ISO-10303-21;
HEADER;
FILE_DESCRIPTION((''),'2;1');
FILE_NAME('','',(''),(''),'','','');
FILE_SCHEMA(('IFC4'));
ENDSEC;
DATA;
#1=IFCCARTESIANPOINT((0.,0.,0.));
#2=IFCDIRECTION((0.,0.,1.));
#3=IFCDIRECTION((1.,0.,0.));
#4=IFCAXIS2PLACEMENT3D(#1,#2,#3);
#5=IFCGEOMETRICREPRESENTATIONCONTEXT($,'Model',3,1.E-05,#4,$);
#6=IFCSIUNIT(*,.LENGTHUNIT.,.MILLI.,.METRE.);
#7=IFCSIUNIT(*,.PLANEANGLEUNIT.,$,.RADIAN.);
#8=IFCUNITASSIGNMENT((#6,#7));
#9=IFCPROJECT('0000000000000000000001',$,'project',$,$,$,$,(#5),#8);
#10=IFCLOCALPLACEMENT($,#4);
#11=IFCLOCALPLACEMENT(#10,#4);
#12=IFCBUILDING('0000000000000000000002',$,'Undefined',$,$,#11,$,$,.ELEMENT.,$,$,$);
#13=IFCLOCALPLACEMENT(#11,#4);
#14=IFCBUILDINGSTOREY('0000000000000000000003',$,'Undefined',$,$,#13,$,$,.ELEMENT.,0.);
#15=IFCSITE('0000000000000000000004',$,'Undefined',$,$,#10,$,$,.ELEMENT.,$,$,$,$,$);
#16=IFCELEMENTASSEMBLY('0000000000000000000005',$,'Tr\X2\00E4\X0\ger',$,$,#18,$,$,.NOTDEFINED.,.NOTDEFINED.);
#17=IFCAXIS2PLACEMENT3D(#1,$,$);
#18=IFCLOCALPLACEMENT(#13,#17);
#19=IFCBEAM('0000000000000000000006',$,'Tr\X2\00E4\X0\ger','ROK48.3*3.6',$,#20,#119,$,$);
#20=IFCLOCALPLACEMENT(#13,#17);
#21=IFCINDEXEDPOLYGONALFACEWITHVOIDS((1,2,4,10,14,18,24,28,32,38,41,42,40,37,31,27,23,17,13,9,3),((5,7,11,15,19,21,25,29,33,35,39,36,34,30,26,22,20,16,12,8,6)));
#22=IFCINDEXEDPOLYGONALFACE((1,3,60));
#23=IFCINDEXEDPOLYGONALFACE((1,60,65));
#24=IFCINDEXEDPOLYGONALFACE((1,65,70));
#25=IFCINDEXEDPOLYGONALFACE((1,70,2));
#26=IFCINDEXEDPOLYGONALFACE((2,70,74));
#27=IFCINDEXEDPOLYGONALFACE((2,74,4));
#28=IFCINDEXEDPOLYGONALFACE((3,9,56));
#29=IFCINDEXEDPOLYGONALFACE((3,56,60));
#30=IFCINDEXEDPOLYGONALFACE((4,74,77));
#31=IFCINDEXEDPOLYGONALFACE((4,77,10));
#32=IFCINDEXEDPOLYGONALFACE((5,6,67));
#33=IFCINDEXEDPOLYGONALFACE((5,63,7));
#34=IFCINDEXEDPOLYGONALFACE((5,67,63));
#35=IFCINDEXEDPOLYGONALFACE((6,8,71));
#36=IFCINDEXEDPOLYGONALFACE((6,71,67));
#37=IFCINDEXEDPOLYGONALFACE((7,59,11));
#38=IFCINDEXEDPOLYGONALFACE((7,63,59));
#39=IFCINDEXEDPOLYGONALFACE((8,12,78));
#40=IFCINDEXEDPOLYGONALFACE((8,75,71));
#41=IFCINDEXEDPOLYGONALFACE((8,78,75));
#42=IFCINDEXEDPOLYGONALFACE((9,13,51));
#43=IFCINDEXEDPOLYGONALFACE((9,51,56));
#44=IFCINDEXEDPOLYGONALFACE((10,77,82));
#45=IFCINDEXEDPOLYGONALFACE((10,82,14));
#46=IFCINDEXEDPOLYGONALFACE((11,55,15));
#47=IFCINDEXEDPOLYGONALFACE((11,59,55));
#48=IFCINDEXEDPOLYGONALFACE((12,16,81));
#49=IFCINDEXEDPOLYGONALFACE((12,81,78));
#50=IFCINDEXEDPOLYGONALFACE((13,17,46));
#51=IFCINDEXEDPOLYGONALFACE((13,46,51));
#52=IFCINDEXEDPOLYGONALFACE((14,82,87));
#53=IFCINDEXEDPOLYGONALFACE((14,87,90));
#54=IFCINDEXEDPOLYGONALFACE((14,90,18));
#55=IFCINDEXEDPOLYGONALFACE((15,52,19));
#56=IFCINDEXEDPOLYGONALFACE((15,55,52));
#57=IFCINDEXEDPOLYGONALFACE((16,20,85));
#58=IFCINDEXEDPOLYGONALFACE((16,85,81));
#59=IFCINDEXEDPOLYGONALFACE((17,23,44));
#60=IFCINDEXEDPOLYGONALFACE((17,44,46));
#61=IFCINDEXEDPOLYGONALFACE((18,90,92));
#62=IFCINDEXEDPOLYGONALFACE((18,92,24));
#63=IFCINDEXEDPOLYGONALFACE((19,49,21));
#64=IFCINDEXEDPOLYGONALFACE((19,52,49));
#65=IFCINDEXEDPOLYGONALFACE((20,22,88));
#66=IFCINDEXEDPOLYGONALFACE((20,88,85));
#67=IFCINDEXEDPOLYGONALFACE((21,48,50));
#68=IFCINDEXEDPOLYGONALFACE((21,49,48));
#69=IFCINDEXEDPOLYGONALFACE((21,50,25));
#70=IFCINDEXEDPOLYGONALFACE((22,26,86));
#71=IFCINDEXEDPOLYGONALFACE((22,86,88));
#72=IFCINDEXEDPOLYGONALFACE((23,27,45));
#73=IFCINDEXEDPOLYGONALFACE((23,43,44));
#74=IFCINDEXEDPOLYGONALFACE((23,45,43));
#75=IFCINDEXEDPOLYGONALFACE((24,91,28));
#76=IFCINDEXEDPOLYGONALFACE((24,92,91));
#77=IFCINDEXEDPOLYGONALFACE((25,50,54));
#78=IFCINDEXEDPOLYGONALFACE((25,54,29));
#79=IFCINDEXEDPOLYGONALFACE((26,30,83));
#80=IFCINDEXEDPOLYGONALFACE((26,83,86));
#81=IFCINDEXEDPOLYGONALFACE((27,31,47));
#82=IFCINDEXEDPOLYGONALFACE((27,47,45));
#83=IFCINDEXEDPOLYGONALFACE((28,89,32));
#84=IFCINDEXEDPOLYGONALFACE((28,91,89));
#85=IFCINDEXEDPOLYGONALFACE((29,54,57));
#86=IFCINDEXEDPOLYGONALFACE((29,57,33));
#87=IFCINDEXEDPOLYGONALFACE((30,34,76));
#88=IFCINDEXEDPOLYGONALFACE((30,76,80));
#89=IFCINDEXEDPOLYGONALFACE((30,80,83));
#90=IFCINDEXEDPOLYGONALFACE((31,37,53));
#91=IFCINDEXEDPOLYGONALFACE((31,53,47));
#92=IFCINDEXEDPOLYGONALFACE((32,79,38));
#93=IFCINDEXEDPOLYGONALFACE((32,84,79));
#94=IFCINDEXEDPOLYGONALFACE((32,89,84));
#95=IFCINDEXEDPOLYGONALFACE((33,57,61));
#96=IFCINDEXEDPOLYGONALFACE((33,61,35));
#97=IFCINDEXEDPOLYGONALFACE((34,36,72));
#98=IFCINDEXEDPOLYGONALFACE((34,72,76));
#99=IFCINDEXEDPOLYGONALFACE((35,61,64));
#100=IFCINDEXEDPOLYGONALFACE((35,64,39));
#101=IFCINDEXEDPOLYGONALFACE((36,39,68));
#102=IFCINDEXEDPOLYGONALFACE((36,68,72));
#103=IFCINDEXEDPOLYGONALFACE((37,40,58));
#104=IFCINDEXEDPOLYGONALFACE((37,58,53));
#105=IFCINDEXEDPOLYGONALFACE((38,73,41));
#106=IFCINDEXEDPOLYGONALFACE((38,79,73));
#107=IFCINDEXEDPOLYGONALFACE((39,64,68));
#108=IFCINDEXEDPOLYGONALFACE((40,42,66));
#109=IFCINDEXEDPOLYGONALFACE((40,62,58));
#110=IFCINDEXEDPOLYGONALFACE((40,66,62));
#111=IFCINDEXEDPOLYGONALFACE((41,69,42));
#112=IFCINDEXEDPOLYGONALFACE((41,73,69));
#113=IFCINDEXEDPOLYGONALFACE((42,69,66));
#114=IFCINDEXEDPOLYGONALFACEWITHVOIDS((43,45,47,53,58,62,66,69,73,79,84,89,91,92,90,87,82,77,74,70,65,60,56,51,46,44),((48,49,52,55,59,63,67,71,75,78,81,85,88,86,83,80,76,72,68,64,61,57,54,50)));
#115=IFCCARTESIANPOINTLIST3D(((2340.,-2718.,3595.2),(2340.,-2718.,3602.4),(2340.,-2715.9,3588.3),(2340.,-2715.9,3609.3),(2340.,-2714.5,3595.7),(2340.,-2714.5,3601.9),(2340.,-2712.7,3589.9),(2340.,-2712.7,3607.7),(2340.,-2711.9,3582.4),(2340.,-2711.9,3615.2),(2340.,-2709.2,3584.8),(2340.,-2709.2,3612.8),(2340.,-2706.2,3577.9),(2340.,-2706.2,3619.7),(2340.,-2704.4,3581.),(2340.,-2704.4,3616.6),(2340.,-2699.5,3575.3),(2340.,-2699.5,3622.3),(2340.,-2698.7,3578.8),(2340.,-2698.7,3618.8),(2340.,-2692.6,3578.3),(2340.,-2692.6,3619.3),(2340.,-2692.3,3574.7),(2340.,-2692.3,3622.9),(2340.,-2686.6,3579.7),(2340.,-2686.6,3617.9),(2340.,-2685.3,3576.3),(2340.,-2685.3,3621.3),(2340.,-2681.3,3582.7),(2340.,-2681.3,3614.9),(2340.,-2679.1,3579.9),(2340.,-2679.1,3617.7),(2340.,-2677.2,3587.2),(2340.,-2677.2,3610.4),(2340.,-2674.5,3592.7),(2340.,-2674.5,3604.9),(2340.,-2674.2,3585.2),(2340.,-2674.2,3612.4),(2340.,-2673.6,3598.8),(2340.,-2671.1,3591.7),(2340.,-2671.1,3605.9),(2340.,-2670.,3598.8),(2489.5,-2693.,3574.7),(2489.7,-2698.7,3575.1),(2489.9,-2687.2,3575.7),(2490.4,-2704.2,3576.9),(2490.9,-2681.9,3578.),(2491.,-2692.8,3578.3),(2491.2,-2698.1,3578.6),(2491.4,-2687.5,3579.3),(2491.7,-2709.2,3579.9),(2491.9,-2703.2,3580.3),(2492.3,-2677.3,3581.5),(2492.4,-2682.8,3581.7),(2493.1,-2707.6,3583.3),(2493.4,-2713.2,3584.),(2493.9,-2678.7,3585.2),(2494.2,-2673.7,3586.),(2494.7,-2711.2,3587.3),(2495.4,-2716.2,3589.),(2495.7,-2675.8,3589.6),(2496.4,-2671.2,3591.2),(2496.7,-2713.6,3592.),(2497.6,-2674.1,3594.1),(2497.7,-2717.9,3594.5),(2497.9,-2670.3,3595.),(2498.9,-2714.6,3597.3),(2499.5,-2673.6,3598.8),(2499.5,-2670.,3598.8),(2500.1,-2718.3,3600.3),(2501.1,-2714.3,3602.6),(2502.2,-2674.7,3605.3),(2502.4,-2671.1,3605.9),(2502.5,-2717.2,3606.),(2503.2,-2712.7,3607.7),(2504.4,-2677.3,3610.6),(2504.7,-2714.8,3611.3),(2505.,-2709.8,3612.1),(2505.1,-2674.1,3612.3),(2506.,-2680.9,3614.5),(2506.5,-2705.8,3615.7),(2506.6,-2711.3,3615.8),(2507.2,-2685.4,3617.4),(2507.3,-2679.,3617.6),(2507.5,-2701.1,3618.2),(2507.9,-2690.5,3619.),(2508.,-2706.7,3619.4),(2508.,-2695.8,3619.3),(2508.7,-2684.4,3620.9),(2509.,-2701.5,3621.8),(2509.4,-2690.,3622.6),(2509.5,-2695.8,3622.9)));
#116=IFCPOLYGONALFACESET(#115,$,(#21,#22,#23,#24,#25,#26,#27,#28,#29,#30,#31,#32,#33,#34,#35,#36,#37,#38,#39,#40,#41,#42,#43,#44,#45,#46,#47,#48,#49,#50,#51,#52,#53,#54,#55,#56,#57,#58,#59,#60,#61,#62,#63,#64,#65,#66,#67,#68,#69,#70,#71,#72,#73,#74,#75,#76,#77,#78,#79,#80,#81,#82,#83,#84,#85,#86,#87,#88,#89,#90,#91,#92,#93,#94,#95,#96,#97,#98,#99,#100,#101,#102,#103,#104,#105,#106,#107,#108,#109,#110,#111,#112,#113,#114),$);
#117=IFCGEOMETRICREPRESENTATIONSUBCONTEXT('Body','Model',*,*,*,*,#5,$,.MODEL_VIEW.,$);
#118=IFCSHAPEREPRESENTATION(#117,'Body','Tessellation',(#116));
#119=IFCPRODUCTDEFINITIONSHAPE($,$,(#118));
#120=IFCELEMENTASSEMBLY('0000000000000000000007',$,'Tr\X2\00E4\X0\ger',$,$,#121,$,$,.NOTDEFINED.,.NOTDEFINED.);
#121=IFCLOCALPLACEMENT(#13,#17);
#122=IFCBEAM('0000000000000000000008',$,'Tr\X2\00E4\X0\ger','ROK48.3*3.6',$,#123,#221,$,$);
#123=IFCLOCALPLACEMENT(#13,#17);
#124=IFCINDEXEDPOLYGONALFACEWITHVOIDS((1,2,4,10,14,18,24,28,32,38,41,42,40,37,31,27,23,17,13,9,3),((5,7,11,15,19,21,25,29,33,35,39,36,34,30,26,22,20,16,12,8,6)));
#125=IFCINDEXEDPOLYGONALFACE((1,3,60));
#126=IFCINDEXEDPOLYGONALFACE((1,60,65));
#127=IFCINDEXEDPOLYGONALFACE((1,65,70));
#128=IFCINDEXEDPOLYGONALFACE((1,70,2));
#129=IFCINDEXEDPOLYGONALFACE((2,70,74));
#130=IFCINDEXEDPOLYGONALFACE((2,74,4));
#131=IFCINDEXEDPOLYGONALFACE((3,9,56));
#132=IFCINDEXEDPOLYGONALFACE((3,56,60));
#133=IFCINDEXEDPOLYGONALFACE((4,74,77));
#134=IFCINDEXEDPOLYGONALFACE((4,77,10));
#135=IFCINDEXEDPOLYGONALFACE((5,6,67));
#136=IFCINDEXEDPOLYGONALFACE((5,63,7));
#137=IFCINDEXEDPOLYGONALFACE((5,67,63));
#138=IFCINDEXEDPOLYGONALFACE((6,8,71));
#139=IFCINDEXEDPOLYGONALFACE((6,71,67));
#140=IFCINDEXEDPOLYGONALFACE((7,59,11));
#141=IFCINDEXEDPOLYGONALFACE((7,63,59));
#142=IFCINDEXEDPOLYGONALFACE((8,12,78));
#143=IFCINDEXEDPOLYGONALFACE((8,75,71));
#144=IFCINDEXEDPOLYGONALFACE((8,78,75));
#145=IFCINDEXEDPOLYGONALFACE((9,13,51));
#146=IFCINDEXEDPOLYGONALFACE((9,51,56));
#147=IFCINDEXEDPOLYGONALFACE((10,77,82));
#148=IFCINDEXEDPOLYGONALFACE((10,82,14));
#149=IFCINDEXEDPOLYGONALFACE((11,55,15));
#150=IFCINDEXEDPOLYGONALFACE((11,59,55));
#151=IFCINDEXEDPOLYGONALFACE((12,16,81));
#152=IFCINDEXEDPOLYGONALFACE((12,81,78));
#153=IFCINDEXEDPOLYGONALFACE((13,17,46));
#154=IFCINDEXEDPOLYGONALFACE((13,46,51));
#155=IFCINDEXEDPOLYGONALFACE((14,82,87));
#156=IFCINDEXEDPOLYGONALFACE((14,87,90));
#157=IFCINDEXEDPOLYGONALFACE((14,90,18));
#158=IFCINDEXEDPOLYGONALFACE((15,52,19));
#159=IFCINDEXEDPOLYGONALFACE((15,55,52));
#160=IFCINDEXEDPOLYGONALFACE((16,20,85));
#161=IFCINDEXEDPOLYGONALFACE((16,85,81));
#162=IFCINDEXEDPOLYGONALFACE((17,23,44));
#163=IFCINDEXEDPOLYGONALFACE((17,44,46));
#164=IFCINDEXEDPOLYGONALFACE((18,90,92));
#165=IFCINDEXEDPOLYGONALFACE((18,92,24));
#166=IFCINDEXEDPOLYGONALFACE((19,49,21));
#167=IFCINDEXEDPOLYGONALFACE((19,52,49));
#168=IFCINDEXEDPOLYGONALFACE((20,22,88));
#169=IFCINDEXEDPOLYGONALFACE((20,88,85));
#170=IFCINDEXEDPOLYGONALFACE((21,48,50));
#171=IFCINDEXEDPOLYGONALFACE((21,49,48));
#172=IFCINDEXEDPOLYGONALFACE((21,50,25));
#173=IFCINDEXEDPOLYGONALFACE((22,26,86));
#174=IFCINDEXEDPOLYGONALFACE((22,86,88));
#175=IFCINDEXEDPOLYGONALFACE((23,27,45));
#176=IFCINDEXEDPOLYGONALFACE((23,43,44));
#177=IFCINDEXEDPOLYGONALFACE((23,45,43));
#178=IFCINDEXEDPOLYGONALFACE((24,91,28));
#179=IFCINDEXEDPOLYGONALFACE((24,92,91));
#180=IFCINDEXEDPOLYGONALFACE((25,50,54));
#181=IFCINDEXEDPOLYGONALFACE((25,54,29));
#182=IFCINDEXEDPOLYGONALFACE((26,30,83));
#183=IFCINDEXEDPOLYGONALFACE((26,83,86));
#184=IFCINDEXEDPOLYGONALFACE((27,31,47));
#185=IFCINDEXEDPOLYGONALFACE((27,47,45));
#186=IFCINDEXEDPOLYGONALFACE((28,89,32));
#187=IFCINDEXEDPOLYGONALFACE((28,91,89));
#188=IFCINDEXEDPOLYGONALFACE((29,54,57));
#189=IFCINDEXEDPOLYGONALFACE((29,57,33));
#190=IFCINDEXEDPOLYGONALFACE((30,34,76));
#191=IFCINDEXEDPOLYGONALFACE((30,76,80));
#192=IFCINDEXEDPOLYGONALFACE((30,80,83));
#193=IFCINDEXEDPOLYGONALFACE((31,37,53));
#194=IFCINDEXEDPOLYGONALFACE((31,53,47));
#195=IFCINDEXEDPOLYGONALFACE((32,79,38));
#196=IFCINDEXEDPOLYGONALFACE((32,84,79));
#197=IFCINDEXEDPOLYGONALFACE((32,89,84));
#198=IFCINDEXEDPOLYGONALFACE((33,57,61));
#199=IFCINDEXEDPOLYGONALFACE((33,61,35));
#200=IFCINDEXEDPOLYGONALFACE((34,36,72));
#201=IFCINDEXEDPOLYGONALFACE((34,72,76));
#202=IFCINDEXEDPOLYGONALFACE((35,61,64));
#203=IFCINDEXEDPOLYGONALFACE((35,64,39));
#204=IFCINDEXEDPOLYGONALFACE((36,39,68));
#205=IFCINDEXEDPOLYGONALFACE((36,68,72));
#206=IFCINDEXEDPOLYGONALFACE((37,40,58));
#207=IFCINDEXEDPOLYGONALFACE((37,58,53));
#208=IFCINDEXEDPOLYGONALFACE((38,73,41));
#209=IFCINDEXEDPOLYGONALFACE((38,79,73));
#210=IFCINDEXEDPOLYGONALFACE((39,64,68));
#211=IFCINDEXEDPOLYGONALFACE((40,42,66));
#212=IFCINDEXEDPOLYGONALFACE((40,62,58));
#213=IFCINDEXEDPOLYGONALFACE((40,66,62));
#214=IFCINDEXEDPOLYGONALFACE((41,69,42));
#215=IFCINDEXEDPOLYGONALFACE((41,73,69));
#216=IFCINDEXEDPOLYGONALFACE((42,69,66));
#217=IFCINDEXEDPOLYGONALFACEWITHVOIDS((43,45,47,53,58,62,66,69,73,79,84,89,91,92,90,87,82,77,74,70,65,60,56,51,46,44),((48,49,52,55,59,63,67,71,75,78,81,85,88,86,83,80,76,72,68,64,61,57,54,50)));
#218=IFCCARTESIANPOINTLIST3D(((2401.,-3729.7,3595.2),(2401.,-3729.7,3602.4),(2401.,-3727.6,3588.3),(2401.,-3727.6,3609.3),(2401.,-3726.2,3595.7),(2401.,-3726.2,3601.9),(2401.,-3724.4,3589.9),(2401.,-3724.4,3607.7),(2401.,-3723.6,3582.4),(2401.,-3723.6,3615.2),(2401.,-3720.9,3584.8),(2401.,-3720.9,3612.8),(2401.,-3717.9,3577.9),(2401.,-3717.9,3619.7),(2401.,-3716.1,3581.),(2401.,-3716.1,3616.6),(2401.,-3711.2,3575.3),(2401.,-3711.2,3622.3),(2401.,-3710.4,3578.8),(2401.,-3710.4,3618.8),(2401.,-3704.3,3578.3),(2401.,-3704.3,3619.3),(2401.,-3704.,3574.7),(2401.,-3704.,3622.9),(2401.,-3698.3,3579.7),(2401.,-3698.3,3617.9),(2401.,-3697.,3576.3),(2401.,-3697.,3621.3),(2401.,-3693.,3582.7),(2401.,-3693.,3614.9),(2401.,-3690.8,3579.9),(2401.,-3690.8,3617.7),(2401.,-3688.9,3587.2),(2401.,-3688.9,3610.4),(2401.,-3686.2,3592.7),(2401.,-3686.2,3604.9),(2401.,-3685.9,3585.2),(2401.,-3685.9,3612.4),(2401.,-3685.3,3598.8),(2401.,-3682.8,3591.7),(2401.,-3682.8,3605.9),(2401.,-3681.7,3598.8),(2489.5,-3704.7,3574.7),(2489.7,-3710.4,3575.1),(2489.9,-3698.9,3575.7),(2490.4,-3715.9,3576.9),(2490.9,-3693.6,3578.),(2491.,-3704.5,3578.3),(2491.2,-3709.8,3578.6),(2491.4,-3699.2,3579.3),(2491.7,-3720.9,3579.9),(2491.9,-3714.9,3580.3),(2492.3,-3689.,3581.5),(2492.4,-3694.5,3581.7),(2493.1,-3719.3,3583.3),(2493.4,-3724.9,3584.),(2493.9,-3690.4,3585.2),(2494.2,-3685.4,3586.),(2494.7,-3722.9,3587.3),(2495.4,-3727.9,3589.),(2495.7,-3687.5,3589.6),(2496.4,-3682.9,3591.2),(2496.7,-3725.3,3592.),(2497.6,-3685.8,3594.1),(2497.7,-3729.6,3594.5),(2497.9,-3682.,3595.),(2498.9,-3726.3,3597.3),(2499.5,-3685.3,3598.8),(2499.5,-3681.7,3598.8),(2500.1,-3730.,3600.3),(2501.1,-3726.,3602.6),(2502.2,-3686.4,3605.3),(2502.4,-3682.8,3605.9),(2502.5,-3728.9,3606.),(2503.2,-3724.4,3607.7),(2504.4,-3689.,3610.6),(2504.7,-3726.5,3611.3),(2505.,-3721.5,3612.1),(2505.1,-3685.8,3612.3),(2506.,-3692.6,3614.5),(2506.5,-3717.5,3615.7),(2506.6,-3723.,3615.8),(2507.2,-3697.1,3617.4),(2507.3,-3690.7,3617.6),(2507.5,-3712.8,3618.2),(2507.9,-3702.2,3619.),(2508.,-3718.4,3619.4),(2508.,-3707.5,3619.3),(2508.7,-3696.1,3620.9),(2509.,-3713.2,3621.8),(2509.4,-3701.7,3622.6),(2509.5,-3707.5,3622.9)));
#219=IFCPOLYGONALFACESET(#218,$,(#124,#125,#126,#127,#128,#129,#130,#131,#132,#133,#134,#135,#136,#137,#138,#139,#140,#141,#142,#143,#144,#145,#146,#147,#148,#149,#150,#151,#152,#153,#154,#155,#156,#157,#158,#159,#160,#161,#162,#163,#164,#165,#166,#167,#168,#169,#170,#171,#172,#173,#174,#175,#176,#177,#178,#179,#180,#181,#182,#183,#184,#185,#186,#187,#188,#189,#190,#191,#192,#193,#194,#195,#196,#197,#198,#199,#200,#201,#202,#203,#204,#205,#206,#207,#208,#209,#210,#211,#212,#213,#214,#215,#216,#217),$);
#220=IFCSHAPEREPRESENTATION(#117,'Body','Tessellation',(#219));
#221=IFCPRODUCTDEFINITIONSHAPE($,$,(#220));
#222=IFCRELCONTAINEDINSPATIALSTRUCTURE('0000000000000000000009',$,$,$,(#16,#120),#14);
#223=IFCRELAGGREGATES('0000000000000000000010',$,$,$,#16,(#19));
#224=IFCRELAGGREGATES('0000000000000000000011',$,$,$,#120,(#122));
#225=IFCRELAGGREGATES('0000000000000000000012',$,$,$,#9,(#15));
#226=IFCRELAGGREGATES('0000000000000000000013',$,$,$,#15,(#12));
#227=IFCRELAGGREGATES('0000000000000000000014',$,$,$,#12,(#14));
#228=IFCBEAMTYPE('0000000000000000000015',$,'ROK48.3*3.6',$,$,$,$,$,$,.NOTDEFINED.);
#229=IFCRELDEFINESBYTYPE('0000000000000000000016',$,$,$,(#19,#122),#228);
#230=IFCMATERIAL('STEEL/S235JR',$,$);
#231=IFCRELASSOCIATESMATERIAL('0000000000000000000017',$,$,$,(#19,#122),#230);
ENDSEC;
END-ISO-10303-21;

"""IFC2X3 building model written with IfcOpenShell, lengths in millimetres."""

from ifc_helpers import new_model, si_unit, frame, origin_with_axes, origin_2d_with_axis, place, context, subcontext, project, spatial, hollow_circle, extrude, clip, halfspace, material, type_object, element, aggregate, save


model = new_model("IFC2X3")

# Units and contexts
model_context = context("Model", 3, precision=1e-05, world=origin_with_axes())
body_context = subcontext(model_context, "Body", "Model", "MODEL_VIEW")
ifc_project = project(units=[si_unit("LENGTHUNIT", "METRE", prefix="MILLI"), si_unit("PLANEANGLEUNIT", "RADIAN")], contexts=[model_context])

# Site, building, storey
site_placement = place(None, origin_with_axes())
site = spatial("IfcSite", under=ifc_project, at=site_placement, Name="Undefined", CompositionType="ELEMENT")
building_placement = place(site_placement, origin_with_axes())
building = spatial("IfcBuilding", under=site, at=building_placement, Name="Undefined", CompositionType="ELEMENT")
storey_placement = place(building_placement, origin_with_axes())
storey = spatial("IfcBuildingStorey", under=building, at=storey_placement, Name="Undefined", CompositionType="ELEMENT", Elevation=0.0)

# Element assembly, beam
assembly_1_placement = place(storey_placement, origin_with_axes())
assembly_1 = element("IfcElementAssembly", 1, at=assembly_1_placement, inside=storey, Name="Träger", AssemblyPlace="NOTDEFINED", PredefinedType="NOTDEFINED")
ifc_material_1 = material(Name="STEEL/S235JR")
beam_type_1 = type_object("IfcBeamType", Name="ROK48.3*3.6", PredefinedType="NOTDEFINED")
beam_1_placement = place(assembly_1_placement, frame((2500.0, -2694.1, 3598.8), z_axis=(0.0, 0.0, 1.0), x_axis=(-1.0, 0.0, 0.0)))
beam_1 = element("IfcBeam", 2, at=beam_1_placement, type_object=beam_type_1, material=ifc_material_1, Name="Träger", Description="ROK48.3*3.6", context=body_context, shape_type="Clipping", body=[
    clip(extrude(hollow_circle(Radius=24.1, WallThickness=3.6, at=origin_2d_with_axis()), frame((160.0, 0.0, 0.0), z_axis=(-1.0, 0.0, 0.0), x_axis=(0.0, -1.0, 0.0)), (0.0, 0.0, 1.0), 169.6), halfspace(frame((-9.5, 0.0, 24.2), z_axis=(-0.923878, 0.0, -0.382686), x_axis=(0.0, -1.0, 0.0)), False)),
])

aggregate(assembly_1, [beam_1])

# Element assembly, beam
assembly_2_placement = place(storey_placement, origin_with_axes())
assembly_2 = element("IfcElementAssembly", 3, at=assembly_2_placement, inside=storey, Name="Träger", AssemblyPlace="NOTDEFINED", PredefinedType="NOTDEFINED")
beam_2_placement = place(assembly_2_placement, frame((2500.0, -3705.9, 3598.8), z_axis=(0.0, 0.0, 1.0), x_axis=(-1.0, 0.0, 0.0)))
beam_2 = element("IfcBeam", 4, at=beam_2_placement, type_object=beam_type_1, material=ifc_material_1, Name="Träger", Description="ROK48.3*3.6", context=body_context, shape_type="Clipping", body=[
    clip(extrude(hollow_circle(Radius=24.1, WallThickness=3.6, at=origin_2d_with_axis()), frame((99.0, 0.0, 0.0), z_axis=(-1.0, 0.0, 0.0), x_axis=(0.0, -1.0, 0.0)), (0.0, 0.0, 1.0), 108.6), halfspace(frame((-9.5, 0.0, 24.2), z_axis=(-0.923878, 0.0, -0.382686), x_axis=(0.0, -1.0, 0.0)), False)),
])

aggregate(assembly_2, [beam_2])

save(model, "model.ifc")
